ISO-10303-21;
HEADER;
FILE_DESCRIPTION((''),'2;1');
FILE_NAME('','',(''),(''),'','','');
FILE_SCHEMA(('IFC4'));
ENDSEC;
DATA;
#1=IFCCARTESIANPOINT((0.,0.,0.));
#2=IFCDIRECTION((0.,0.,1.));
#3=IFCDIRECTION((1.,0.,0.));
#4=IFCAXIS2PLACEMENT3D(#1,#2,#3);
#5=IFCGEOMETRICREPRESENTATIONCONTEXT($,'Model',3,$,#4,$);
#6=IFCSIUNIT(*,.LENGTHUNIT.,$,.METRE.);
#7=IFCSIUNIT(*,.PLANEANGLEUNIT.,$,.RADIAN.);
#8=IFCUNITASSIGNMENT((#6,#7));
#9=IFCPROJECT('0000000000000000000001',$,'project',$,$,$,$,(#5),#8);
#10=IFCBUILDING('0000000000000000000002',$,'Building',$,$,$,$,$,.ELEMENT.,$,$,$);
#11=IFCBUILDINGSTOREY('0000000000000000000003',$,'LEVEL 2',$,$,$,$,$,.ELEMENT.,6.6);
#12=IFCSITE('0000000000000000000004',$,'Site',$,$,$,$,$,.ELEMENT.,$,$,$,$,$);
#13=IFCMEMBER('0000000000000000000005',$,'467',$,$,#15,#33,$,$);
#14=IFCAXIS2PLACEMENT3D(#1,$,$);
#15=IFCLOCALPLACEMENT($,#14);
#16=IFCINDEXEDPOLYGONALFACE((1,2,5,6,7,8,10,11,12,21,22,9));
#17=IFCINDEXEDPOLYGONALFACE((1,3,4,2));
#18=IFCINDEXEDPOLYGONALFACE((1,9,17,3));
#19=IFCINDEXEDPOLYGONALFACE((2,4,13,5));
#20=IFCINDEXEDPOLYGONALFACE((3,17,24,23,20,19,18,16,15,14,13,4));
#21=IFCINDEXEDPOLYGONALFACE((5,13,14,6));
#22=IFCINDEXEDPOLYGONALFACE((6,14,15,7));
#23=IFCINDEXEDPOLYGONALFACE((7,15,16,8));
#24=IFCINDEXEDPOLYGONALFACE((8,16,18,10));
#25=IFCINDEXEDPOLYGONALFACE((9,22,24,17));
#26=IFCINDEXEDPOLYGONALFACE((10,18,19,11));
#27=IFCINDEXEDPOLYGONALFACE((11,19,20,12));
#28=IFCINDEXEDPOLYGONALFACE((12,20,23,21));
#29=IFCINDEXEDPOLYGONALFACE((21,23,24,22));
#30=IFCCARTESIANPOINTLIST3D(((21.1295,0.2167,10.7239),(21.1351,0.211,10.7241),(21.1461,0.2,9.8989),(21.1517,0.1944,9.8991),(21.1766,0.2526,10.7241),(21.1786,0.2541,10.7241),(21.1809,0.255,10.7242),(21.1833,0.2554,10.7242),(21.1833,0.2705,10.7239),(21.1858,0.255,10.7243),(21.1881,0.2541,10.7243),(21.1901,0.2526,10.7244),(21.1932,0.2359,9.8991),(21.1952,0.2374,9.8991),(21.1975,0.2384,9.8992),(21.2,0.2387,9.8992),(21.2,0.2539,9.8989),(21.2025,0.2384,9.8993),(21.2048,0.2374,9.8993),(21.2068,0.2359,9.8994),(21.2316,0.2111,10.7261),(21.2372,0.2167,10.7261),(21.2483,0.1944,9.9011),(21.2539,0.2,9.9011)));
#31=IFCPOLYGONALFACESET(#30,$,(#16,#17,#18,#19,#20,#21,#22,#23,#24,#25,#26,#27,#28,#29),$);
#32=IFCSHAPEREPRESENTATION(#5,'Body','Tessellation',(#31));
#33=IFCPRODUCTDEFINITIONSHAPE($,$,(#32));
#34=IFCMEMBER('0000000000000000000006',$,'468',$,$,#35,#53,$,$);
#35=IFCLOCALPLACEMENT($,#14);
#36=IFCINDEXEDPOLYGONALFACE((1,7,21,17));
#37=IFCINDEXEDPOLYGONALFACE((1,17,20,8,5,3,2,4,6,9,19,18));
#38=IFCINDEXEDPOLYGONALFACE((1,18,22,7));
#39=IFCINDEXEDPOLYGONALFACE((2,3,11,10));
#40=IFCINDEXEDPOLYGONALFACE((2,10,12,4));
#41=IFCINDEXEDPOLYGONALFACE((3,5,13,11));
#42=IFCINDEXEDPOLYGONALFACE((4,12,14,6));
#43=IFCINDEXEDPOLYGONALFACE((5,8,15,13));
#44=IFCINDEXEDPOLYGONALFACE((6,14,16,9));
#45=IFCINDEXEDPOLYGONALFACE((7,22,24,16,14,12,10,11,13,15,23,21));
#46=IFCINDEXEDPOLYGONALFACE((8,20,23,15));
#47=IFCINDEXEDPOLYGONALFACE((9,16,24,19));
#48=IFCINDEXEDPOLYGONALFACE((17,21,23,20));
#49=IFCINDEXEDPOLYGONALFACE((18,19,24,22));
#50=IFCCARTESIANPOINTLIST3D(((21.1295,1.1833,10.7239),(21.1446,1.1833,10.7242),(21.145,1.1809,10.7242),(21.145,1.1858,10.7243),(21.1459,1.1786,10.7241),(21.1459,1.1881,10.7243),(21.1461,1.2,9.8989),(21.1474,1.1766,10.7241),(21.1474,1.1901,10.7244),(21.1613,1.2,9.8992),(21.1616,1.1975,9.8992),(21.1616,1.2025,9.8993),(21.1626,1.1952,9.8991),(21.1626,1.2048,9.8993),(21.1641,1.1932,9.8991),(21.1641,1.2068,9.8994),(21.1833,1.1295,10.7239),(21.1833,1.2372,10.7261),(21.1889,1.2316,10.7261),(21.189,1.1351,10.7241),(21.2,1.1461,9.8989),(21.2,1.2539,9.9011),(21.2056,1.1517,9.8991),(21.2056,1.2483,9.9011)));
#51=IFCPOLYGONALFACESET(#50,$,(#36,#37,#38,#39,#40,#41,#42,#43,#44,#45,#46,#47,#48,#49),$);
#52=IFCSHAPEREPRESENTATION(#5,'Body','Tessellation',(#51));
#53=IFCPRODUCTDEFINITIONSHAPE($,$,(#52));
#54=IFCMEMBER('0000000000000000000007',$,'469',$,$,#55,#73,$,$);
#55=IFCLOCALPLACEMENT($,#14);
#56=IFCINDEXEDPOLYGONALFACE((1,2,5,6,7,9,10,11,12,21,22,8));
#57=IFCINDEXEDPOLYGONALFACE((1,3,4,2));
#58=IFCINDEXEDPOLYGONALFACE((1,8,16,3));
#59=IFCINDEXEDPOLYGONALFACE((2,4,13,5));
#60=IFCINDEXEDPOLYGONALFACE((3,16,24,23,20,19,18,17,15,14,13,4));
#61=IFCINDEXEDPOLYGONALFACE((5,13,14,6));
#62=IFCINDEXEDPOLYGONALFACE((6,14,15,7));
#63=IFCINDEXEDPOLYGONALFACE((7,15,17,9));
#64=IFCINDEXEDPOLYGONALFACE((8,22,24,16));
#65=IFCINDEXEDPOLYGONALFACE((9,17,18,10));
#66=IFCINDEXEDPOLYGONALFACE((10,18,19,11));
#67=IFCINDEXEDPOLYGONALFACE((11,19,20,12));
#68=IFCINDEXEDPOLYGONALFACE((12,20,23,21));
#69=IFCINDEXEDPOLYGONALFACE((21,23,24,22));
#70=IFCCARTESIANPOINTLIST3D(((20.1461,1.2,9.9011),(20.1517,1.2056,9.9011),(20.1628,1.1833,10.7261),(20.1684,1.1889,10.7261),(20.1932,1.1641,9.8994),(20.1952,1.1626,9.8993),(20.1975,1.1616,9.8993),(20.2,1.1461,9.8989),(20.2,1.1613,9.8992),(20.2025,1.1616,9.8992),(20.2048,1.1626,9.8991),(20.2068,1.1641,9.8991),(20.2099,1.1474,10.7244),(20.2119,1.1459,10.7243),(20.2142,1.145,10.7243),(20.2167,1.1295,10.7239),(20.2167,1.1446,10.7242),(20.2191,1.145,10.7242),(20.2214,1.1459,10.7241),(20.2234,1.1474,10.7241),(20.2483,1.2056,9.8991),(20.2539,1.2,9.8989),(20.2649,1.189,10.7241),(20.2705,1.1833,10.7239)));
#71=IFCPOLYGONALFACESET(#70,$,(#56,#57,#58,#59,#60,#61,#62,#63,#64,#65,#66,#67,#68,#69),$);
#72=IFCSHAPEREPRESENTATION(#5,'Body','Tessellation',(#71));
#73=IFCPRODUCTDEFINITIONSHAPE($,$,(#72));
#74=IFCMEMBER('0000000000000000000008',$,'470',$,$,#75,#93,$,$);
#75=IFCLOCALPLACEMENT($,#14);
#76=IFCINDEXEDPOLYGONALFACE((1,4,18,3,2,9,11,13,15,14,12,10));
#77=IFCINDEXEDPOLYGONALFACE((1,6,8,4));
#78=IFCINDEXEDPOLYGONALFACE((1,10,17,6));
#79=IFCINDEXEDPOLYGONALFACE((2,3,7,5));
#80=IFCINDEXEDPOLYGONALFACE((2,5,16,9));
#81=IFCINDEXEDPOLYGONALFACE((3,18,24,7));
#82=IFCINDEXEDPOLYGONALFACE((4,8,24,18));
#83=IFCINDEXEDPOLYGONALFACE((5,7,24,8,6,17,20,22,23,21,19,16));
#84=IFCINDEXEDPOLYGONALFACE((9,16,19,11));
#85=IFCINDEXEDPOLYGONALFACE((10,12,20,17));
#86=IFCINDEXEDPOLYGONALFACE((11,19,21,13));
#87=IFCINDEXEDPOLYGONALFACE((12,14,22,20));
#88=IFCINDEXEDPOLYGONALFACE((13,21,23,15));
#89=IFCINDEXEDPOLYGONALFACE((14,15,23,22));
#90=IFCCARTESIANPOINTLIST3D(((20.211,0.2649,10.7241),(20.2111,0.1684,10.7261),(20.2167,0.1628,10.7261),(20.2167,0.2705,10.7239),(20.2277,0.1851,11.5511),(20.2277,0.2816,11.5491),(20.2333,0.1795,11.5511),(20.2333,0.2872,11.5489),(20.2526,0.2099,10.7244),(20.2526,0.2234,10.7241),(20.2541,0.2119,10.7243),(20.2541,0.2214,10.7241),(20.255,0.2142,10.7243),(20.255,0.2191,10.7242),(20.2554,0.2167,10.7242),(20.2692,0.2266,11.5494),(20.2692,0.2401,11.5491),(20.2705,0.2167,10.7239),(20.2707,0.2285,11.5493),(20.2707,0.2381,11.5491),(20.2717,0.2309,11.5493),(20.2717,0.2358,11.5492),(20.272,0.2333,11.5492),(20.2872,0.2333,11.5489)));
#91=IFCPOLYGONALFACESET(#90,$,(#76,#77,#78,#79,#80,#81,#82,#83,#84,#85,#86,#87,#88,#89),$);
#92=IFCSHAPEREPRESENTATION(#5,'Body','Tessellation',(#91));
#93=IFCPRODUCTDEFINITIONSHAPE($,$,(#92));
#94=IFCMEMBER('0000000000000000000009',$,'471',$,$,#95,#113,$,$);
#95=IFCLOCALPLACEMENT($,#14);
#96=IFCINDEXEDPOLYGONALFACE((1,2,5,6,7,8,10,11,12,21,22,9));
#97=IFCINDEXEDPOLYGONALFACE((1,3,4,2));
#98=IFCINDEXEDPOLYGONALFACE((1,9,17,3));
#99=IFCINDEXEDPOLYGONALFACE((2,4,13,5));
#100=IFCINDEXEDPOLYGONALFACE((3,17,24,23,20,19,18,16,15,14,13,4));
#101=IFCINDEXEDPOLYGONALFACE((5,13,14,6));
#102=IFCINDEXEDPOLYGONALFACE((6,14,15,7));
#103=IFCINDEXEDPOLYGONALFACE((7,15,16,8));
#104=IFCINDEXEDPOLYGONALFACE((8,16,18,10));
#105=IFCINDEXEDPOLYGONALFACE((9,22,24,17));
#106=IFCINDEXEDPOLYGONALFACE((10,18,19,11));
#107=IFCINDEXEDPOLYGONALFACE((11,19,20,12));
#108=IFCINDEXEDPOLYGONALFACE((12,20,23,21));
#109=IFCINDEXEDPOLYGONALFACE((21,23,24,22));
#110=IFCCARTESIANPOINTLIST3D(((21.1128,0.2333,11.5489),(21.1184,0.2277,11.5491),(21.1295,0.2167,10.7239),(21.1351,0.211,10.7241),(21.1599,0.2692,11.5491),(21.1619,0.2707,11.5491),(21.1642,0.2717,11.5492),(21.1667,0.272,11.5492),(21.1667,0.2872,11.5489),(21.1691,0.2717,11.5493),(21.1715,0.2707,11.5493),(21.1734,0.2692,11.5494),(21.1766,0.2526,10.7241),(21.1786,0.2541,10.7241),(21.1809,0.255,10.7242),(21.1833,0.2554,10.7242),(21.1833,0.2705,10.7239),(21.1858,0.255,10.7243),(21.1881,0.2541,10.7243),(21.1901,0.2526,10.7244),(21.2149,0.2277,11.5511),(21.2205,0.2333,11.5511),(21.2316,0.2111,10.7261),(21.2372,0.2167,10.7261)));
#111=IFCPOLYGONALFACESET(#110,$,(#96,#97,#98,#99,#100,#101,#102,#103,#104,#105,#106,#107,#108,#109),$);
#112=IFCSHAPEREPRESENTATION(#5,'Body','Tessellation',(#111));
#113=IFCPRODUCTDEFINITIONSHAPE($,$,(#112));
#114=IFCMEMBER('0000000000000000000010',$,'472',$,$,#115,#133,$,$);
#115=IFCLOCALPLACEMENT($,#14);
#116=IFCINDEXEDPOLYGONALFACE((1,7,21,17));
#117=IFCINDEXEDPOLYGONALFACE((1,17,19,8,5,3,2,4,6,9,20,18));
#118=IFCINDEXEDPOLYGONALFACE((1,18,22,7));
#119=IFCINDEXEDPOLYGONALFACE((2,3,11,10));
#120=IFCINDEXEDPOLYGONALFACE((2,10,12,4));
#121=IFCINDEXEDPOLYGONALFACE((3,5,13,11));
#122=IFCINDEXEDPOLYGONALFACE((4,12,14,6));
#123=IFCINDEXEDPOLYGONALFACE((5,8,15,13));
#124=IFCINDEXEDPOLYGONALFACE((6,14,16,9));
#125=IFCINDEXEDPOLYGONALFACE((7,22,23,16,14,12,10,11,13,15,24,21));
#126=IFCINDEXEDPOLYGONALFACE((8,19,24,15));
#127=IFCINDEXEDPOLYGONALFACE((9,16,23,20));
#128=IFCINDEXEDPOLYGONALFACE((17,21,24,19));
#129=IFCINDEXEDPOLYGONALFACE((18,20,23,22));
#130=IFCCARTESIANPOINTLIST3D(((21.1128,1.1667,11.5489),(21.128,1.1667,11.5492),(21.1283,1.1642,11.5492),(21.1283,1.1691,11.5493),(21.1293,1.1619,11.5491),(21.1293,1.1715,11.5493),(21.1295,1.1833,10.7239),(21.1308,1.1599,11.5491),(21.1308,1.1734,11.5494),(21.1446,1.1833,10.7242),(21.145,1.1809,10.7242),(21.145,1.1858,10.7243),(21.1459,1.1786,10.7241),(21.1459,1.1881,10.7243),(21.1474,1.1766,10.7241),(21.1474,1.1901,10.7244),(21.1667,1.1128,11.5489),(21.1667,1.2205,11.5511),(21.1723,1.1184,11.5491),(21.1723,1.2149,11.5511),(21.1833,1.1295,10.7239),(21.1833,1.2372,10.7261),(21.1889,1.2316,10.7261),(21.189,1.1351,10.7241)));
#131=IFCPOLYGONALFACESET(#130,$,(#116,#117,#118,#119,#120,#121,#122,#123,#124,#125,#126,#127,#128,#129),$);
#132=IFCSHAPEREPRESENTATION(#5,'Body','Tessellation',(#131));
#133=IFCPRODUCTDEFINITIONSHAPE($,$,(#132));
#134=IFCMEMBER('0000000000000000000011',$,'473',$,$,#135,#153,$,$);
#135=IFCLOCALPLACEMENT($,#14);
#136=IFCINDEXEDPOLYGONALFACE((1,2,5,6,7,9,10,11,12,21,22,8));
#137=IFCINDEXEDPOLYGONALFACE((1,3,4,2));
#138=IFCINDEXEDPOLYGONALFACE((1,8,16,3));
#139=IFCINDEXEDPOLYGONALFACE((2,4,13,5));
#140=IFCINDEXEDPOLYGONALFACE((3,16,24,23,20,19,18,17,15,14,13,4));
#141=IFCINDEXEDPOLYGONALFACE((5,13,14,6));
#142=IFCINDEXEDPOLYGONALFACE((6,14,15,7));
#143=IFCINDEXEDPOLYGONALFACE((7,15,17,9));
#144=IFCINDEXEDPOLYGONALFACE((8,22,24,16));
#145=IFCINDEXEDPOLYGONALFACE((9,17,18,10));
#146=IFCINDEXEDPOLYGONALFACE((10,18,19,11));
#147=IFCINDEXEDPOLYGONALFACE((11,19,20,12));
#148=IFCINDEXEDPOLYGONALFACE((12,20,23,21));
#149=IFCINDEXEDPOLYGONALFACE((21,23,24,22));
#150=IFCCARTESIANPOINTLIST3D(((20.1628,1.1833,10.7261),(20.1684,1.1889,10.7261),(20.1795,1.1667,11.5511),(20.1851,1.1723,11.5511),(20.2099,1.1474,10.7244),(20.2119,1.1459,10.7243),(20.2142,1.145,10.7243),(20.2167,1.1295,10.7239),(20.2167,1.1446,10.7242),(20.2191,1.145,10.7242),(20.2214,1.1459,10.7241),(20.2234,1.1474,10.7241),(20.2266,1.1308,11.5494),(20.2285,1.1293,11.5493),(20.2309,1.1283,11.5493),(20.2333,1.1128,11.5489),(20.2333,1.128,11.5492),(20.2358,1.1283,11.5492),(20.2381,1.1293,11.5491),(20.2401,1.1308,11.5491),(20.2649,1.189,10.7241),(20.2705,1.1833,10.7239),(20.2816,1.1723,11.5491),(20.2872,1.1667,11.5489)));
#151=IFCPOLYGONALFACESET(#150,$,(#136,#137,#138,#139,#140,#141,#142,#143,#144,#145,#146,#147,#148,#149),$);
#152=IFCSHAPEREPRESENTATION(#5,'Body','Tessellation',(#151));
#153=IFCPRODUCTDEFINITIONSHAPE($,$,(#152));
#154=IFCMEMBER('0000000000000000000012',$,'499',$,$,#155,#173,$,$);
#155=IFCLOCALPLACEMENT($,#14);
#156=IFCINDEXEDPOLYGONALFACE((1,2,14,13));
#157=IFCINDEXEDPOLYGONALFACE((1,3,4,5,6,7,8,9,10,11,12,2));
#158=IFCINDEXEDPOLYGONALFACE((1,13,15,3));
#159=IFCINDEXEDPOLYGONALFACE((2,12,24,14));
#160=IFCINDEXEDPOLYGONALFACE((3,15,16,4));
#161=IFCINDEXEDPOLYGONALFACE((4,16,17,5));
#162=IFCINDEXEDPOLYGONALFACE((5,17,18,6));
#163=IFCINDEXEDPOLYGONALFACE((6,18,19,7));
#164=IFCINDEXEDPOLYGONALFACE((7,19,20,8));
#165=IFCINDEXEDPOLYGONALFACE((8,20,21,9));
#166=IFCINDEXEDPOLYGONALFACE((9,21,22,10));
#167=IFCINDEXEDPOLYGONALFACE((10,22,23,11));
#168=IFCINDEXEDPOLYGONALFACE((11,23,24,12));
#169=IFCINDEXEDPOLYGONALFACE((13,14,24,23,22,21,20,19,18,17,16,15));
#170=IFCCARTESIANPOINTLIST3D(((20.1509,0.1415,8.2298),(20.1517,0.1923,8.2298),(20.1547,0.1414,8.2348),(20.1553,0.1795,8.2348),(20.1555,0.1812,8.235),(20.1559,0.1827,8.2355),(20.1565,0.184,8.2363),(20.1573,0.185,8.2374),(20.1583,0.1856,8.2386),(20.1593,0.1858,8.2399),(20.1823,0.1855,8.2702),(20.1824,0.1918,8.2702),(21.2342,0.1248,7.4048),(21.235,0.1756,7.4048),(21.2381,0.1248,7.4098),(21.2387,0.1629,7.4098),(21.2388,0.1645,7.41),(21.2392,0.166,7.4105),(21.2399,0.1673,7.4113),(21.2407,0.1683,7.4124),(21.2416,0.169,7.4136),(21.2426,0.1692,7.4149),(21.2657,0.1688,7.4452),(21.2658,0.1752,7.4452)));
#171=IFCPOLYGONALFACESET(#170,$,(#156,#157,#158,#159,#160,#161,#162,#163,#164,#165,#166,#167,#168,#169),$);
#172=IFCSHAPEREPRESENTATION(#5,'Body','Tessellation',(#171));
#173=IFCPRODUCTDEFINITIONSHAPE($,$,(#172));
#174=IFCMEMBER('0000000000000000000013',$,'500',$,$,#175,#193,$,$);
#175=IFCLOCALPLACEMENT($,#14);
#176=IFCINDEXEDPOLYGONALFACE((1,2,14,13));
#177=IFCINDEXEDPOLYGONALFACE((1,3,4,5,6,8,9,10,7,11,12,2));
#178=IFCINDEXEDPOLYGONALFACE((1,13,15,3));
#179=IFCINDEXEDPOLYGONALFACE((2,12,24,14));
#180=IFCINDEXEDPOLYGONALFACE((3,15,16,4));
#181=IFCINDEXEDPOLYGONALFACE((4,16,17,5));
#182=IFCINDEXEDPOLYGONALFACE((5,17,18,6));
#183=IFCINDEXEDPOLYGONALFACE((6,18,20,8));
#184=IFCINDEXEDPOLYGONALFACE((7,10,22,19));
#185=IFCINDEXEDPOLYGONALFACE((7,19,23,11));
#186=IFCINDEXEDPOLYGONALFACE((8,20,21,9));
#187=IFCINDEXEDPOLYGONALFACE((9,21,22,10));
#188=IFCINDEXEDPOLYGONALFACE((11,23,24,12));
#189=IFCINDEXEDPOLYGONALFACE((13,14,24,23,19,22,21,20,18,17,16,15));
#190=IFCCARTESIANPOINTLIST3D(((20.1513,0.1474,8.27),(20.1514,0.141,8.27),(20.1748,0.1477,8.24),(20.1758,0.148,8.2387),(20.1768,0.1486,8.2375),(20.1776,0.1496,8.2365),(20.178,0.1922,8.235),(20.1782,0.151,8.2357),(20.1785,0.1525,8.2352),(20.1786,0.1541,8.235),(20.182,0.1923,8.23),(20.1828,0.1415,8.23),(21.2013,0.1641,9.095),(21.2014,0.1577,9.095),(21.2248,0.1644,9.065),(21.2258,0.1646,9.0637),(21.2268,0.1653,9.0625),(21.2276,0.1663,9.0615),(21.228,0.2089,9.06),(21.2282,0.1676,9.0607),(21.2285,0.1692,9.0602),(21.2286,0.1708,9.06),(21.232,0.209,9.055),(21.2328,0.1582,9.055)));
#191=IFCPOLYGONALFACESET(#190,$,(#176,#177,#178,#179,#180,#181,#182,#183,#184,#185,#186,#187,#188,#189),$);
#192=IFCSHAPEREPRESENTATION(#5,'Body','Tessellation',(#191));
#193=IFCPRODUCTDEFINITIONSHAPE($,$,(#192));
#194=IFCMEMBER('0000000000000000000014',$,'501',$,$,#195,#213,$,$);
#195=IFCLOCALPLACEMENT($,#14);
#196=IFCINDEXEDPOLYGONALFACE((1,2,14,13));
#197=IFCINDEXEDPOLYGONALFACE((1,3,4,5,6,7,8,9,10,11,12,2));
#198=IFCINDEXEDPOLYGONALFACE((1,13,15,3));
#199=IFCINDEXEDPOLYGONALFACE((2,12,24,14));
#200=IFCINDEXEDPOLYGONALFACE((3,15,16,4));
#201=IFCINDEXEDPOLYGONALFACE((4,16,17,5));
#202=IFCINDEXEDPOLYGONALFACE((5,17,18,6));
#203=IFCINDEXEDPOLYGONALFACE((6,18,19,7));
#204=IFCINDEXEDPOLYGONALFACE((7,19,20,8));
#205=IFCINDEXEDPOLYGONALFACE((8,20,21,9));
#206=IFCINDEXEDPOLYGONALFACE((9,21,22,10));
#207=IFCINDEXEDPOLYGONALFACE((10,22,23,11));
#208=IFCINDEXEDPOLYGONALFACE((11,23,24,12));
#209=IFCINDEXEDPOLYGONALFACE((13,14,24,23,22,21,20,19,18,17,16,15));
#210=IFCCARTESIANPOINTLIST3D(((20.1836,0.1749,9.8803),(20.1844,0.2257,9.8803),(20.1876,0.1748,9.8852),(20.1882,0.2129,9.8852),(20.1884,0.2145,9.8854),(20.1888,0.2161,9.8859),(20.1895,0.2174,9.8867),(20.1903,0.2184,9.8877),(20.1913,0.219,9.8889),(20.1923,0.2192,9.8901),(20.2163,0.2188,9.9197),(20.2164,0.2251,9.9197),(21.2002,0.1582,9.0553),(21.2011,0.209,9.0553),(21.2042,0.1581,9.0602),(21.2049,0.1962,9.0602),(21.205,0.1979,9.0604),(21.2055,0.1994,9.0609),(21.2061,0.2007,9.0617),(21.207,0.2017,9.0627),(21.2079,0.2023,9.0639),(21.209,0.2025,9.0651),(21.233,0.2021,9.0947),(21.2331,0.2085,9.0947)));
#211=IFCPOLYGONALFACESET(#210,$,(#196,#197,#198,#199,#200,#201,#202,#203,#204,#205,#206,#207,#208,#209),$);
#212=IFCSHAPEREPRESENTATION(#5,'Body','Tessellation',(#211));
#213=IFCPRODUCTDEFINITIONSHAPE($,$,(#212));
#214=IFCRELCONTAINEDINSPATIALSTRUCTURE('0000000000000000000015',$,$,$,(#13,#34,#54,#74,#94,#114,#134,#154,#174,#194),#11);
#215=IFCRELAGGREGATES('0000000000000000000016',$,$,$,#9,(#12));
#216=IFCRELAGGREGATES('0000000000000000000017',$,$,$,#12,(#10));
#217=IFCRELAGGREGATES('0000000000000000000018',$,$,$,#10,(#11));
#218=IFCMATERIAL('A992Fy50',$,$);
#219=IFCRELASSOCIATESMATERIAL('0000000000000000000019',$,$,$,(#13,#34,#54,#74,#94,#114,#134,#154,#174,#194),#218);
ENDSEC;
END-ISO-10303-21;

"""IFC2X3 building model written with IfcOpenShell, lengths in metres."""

from ifc_helpers import new_model, si_unit, frame, origin_with_axes, origin_2d_with_axis, place, context, project, spatial, l_section, extrude, material, element, save


model = new_model("IFC2X3")

# Units and contexts
model_context = context("Model", 3, world=origin_with_axes())
ifc_project = project(units=[si_unit("LENGTHUNIT", "METRE"), si_unit("PLANEANGLEUNIT", "RADIAN")], contexts=[model_context])

# Site, building, storey
site = spatial("IfcSite", under=ifc_project, Name="Site", CompositionType="ELEMENT")
building = spatial("IfcBuilding", under=site, Name="Building", CompositionType="ELEMENT")
storey = spatial("IfcBuildingStorey", under=building, Name="LEVEL 2", CompositionType="ELEMENT", Elevation=6.6)

# Members
ifc_material = material(Name="A992Fy50")
for number, where, z_axis, x_axis, name in (
    (1, (21.2, 0.2, 9.9), (-0.020194, 0.020194, 0.999592), (-0.707107, -0.707107, 0.0), "467"),
    (2, (21.2, 1.2, 9.9), (-0.020194, -0.020194, 0.999592), (0.707107, -0.707107, 0.0), "468"),
    (3, (20.2, 1.2, 9.9), (0.020194, -0.020194, 0.999592), (0.707107, 0.707107, 0.0), "469"),
    (4, (20.2167, 0.2167, 10.725), (0.020194, 0.020194, 0.999592), (-0.707107, 0.707107, 0.0), "470"),
    (5, (21.1833, 0.2167, 10.725), (-0.020194, 0.020194, 0.999592), (-0.707107, -0.707107, 0.0), "471"),
    (6, (21.1833, 1.1833, 10.725), (-0.020194, -0.020194, 0.999592), (0.707107, -0.707107, 0.0), "472"),
    (7, (20.2167, 1.1833, 10.725), (0.020194, -0.020194, 0.999592), (0.707107, 0.707107, 0.0), "473"),
):
    element("IfcMember", number, at=place(None, frame(where, z_axis=z_axis, x_axis=x_axis)), inside=storey, material=ifc_material, Name=name, context=model_context, shape_type="SweptSolid", body=[
        extrude(l_section(Depth=0.0762, Width=0.0762, Thickness=0.0079, FilletRadius=0.0096, at=origin_2d_with_axis()), origin_with_axes(), (0.0, 0.0, 1.0), 0.8253),
    ])
member_1_placement = place(None, frame((21.25, 0.15, 7.425), z_axis=(-0.795513, 0.012239, 0.605813), x_axis=(-0.015383, -0.999882, 0.0)))
element("IfcMember", 8, at=member_1_placement, inside=storey, material=ifc_material, Name="499", context=model_context, shape_type="SweptSolid", body=[
    extrude(l_section(Depth=0.0508, Width=0.0508, Thickness=0.0063, FilletRadius=0.0063, at=origin_2d_with_axis()), origin_with_axes(), (0.0, 0.0, 1.0), 1.3618),
])
member_2_placement = place(None, frame((20.1667, 0.1667, 8.25), z_axis=(0.786257, 0.01248, 0.617773), x_axis=(-0.014924, 0.999889, 0.0)))
element("IfcMember", 9, at=member_2_placement, inside=storey, material=ifc_material, Name="500", context=model_context, shape_type="SweptSolid", body=[
    extrude(l_section(Depth=0.0508, Width=0.0508, Thickness=0.0063, FilletRadius=0.0063, at=origin_2d_with_axis()), origin_with_axes(), (0.0, 0.0, 1.0), 1.3354),
])
member_3_placement = place(None, frame((21.2167, 0.1833, 9.075), z_axis=(-0.77644, 0.012729, 0.630062), x_axis=(-0.016391, -0.999866, 0.0)))
element("IfcMember", 10, at=member_3_placement, inside=storey, material=ifc_material, Name="501", context=model_context, shape_type="SweptSolid", body=[
    extrude(l_section(Depth=0.0508, Width=0.0508, Thickness=0.0063, FilletRadius=0.0063, at=origin_2d_with_axis()), origin_with_axes(), (0.0, 0.0, 1.0), 1.3094),
])

save(model, "model.ifc")
